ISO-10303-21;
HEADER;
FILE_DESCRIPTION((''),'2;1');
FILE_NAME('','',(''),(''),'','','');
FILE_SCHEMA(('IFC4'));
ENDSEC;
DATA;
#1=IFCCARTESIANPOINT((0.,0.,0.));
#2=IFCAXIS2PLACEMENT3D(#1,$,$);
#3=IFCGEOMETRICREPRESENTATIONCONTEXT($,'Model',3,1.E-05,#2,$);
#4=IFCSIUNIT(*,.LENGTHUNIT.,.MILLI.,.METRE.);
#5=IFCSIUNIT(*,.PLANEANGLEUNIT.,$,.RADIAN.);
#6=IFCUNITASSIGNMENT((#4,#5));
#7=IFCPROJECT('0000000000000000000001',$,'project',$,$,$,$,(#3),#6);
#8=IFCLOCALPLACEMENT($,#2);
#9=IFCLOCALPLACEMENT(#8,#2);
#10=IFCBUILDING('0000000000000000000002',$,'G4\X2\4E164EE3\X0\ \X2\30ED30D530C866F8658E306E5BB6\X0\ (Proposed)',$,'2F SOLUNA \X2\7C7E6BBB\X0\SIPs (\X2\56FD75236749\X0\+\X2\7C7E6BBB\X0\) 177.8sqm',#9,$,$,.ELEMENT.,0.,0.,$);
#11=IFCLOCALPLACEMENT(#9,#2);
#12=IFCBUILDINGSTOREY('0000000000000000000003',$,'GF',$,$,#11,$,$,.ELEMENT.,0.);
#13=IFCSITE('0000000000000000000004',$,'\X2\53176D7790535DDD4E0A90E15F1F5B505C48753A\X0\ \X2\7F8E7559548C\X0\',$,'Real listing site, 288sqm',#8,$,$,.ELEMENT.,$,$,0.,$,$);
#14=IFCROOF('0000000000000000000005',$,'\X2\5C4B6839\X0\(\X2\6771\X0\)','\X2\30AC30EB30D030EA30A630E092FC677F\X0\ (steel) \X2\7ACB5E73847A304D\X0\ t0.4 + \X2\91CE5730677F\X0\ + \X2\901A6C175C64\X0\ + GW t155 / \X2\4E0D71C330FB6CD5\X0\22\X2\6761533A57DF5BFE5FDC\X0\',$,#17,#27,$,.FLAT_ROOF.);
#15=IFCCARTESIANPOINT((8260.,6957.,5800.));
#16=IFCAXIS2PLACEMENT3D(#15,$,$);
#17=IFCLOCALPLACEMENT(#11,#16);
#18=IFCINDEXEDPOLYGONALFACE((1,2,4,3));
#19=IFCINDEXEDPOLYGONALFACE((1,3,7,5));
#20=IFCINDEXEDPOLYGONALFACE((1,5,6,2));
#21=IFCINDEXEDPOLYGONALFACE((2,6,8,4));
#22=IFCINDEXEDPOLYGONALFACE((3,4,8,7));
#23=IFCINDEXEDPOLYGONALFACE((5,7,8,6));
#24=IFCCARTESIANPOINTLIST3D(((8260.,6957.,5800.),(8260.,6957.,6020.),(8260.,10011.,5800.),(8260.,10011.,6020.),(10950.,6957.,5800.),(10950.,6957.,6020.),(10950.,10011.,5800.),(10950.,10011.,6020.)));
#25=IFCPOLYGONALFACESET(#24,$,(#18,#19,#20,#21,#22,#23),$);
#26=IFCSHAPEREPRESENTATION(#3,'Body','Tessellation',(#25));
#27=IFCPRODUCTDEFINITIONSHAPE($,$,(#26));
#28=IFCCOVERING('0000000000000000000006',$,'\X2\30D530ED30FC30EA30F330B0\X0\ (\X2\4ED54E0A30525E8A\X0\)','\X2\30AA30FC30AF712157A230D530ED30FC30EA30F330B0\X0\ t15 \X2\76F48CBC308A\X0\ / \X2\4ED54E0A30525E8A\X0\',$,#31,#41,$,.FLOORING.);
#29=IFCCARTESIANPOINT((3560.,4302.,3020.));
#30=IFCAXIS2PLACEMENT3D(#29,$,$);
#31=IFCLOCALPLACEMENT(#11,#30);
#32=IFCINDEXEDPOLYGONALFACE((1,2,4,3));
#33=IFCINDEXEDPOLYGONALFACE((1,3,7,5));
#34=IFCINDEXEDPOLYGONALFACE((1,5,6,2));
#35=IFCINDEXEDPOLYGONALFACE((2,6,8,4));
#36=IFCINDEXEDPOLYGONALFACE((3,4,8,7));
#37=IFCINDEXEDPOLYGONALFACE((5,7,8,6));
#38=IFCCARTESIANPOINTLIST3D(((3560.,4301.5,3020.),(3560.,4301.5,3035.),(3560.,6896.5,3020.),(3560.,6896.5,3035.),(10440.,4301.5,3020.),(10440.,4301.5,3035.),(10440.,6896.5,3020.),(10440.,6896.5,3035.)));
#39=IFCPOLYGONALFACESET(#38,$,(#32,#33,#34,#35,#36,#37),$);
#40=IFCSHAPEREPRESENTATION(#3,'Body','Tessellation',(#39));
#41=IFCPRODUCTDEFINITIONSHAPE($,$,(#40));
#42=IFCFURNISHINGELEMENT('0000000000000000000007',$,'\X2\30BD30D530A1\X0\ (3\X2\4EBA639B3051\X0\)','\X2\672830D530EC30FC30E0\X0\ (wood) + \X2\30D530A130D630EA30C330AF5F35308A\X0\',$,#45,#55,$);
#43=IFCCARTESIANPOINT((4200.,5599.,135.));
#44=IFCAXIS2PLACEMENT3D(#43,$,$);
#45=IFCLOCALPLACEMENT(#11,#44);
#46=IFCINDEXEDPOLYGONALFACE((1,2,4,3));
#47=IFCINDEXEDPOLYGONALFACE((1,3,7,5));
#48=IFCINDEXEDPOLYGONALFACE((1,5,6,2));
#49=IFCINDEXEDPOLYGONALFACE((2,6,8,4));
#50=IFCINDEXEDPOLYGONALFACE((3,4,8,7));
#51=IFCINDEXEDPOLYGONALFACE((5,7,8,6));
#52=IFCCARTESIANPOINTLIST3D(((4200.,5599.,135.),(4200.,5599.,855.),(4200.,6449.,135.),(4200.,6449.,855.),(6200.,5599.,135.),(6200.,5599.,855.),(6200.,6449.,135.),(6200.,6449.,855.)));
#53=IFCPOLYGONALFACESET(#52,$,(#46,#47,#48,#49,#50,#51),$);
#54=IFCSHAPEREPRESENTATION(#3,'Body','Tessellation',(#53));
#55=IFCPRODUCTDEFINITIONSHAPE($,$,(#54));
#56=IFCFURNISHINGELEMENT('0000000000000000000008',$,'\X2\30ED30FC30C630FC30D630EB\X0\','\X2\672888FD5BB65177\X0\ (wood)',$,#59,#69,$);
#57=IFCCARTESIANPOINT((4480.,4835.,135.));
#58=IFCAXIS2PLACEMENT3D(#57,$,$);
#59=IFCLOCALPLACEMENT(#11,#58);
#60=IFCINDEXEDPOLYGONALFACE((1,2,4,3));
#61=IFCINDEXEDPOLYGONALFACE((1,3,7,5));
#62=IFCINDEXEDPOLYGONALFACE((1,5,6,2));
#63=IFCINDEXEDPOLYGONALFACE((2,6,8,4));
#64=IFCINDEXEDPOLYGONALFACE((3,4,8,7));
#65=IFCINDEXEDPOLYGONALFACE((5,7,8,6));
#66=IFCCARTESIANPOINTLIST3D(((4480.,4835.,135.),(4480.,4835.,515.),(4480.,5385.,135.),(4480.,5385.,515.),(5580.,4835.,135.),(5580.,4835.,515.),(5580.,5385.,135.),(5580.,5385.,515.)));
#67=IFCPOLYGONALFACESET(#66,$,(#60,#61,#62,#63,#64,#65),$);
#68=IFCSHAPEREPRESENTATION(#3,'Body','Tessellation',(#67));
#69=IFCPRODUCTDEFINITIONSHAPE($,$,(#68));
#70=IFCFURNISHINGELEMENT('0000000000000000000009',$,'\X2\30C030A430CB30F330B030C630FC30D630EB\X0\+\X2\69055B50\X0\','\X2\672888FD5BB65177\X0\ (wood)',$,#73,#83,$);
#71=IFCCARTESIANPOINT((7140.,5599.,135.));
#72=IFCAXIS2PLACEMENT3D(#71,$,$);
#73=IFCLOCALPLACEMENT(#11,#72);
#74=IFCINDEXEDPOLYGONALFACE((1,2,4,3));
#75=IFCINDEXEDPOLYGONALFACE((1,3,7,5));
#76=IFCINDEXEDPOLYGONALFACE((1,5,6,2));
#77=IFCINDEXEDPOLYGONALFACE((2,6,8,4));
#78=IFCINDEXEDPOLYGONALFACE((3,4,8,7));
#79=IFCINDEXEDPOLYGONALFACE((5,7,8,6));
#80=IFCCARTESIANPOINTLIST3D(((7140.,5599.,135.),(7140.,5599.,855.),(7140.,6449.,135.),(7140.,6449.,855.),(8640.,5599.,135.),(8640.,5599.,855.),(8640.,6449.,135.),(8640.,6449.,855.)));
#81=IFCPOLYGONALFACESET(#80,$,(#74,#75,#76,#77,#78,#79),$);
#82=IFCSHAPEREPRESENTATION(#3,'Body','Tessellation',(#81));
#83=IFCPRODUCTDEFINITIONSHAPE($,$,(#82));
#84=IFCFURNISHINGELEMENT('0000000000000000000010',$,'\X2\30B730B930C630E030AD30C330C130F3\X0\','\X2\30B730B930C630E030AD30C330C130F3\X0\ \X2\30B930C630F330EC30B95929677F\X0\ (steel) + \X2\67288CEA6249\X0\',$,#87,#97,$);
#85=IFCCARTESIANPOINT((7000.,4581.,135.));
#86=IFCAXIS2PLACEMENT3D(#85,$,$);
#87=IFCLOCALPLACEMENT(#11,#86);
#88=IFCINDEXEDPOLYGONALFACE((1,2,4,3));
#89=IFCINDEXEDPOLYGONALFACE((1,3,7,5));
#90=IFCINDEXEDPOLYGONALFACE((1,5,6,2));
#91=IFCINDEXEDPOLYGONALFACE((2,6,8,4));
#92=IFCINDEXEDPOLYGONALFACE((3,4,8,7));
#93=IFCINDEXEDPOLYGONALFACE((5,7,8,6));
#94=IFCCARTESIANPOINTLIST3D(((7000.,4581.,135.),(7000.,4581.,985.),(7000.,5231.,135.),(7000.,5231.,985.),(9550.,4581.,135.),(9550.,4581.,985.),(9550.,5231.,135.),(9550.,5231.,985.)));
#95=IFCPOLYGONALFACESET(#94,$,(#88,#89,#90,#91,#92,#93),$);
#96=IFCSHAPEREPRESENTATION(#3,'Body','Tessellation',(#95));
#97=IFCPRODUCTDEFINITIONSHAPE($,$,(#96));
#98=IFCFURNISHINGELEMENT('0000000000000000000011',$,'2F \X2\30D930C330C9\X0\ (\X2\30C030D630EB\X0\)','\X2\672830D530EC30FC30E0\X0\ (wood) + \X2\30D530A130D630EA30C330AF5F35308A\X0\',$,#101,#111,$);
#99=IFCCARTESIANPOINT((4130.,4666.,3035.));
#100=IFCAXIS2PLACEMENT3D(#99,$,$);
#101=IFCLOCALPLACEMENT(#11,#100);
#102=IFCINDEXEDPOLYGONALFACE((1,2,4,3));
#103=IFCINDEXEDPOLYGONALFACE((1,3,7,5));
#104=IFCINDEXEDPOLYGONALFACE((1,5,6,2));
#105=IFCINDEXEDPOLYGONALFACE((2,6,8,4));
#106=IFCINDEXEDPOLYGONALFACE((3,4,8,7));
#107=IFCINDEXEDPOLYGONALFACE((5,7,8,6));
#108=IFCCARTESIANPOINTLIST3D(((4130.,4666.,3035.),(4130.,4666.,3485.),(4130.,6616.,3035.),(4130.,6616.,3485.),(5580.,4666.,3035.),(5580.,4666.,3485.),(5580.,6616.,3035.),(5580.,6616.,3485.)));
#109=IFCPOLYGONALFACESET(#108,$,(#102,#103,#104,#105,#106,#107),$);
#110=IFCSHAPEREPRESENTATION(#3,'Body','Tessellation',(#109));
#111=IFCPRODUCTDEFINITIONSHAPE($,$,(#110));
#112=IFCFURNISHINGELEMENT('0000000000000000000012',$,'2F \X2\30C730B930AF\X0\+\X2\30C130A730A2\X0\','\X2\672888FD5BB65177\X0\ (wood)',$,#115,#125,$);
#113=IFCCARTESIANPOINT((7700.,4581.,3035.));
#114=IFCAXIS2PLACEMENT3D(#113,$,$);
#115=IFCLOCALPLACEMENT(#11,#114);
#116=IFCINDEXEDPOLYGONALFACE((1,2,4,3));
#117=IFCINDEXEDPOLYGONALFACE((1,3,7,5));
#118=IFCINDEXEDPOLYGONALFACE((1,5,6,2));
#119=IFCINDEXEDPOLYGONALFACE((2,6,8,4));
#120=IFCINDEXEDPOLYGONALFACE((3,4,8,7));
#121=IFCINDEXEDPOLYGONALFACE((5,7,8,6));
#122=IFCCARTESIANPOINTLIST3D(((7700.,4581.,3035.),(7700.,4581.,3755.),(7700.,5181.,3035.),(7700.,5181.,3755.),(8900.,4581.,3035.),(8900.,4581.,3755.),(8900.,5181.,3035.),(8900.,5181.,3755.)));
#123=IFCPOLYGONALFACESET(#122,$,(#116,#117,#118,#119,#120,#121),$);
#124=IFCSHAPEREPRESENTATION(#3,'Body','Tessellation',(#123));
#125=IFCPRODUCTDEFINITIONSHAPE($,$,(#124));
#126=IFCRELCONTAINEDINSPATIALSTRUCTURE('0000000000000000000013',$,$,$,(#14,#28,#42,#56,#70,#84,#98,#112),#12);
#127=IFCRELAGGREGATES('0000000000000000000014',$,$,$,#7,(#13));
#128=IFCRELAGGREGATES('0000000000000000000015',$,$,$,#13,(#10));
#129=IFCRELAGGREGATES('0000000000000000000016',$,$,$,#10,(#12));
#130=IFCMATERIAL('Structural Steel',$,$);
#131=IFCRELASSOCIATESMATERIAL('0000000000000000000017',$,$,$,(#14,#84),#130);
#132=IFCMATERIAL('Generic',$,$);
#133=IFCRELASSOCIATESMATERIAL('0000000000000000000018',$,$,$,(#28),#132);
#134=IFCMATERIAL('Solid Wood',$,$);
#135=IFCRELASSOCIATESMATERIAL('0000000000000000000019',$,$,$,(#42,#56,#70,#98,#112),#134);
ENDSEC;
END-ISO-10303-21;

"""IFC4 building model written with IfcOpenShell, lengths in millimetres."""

from ifc_helpers import new_model, si_unit, frame, frame_2d, origin, place, context, project, spatial, rectangle, extrude, material, element, save


model = new_model("IFC4")

# Units and contexts
model_context = context("Model", 3, precision=1e-05, world=origin())
ifc_project = project(units=[si_unit("LENGTHUNIT", "METRE", prefix="MILLI"), si_unit("PLANEANGLEUNIT", "RADIAN")], contexts=[model_context])

# Site, building, storey
site_placement = place(None, origin())
site = spatial("IfcSite", under=ifc_project, at=site_placement, Name="北海道川上郡弟子屈町 美留和", ObjectType="Real listing site, 288sqm", CompositionType="ELEMENT", RefElevation=0.0)
building_placement = place(site_placement, origin())
building = spatial("IfcBuilding", under=site, at=building_placement, Name="G4世代 ロフト書斎の家 (Proposed)", ObjectType="2F SOLUNA 籾殻SIPs (国産杉+籾殻) 177.8sqm", CompositionType="ELEMENT", ElevationOfRefHeight=0.0, ElevationOfTerrain=0.0)
storey_placement = place(building_placement, origin())
storey = spatial("IfcBuildingStorey", under=building, at=storey_placement, Name="GF", CompositionType="ELEMENT", Elevation=0.0)

# Shared definitions
ifc_material_1 = material(Name="Solid Wood")

# Shared definitions
ifc_material_2 = material(Name="Generic")

# Roof
ifc_material_3 = material(Name="Structural Steel")
roof_placement = place(storey_placement, frame((8260.0, 6957.0, 5800.0)))
element("IfcRoof", 1, at=roof_placement, inside=storey, material=ifc_material_3, Name="屋根(東)", Description="ガルバリウム鋼板 (steel) 立平葺き t0.4 + 野地板 + 通気層 + GW t155 / 不燃・法22条区域対応", PredefinedType="FLAT_ROOF", context=model_context, shape_type="SweptSolid", body=[
    extrude(rectangle(XDim=2690.0, YDim=3054.0, at=frame_2d((1345.0, 1527.0))), frame((8260.0, 6957.0, 5800.0)), (0.0, 0.0, 1.0), 220.0),
])

# Covering
covering_placement = place(storey_placement, frame((3560.0, 4302.0, 3020.0)))
element("IfcCovering", 2, at=covering_placement, inside=storey, material=ifc_material_2, Name="フローリング (仕上げ床)", Description="オーク無垢フローリング t15 直貼り / 仕上げ床", PredefinedType="FLOORING", context=model_context, shape_type="SweptSolid", body=[
    extrude(rectangle(XDim=6880.0, YDim=2595.0, at=frame_2d((3440.0, 1297.0))), frame((3560.0, 4302.0, 3020.0)), (0.0, 0.0, 1.0), 15.0),
])

# Furnishing elements
furnishing_1_placement = place(storey_placement, frame((4200.0, 5599.0, 135.0)))
element("IfcFurnishingElement", 3, at=furnishing_1_placement, inside=storey, material=ifc_material_1, Name="ソファ (3人掛け)", Description="木フレーム (wood) + ファブリック張り", context=model_context, shape_type="SweptSolid", body=[
    extrude(rectangle(XDim=2000.0, YDim=850.0, at=frame_2d((1000.0, 425.0))), frame((4200.0, 5599.0, 135.0)), (0.0, 0.0, 1.0), 720.0),
])
furnishing_2_placement = place(storey_placement, frame((4480.0, 4835.0, 135.0)))
element("IfcFurnishingElement", 4, at=furnishing_2_placement, inside=storey, material=ifc_material_1, Name="ローテーブル", Description="木製家具 (wood)", context=model_context, shape_type="SweptSolid", body=[
    extrude(rectangle(XDim=1100.0, YDim=550.0, at=frame_2d((550.0, 275.0))), frame((4480.0, 4835.0, 135.0)), (0.0, 0.0, 1.0), 380.0),
])
furnishing_3_placement = place(storey_placement, frame((7140.0, 5599.0, 135.0)))
element("IfcFurnishingElement", 5, at=furnishing_3_placement, inside=storey, material=ifc_material_1, Name="ダイニングテーブル+椅子", Description="木製家具 (wood)", context=model_context, shape_type="SweptSolid", body=[
    extrude(rectangle(XDim=1500.0, YDim=850.0, at=frame_2d((750.0, 425.0))), frame((7140.0, 5599.0, 135.0)), (0.0, 0.0, 1.0), 720.0),
])
furnishing_4_placement = place(storey_placement, frame((7000.0, 4581.0, 135.0)))
element("IfcFurnishingElement", 6, at=furnishing_4_placement, inside=storey, material=ifc_material_3, Name="システムキッチン", Description="システムキッチン ステンレス天板 (steel) + 木質扉", context=model_context, shape_type="SweptSolid", body=[
    extrude(rectangle(XDim=2550.0, YDim=650.0, at=frame_2d((1275.0, 325.0))), frame((7000.0, 4581.0, 135.0)), (0.0, 0.0, 1.0), 850.0),
])
furnishing_5_placement = place(storey_placement, frame((4130.0, 4666.0, 3035.0)))
element("IfcFurnishingElement", 7, at=furnishing_5_placement, inside=storey, material=ifc_material_1, Name="2F ベッド (ダブル)", Description="木フレーム (wood) + ファブリック張り", context=model_context, shape_type="SweptSolid", body=[
    extrude(rectangle(XDim=1450.0, YDim=1950.0, at=frame_2d((725.0, 975.0))), frame((4130.0, 4666.0, 3035.0)), (0.0, 0.0, 1.0), 450.0),
])
furnishing_6_placement = place(storey_placement, frame((7700.0, 4581.0, 3035.0)))
element("IfcFurnishingElement", 8, at=furnishing_6_placement, inside=storey, material=ifc_material_1, Name="2F デスク+チェア", Description="木製家具 (wood)", context=model_context, shape_type="SweptSolid", body=[
    extrude(rectangle(XDim=1200.0, YDim=600.0, at=frame_2d((600.0, 300.0))), frame((7700.0, 4581.0, 3035.0)), (0.0, 0.0, 1.0), 720.0),
])

save(model, "model.ifc")
